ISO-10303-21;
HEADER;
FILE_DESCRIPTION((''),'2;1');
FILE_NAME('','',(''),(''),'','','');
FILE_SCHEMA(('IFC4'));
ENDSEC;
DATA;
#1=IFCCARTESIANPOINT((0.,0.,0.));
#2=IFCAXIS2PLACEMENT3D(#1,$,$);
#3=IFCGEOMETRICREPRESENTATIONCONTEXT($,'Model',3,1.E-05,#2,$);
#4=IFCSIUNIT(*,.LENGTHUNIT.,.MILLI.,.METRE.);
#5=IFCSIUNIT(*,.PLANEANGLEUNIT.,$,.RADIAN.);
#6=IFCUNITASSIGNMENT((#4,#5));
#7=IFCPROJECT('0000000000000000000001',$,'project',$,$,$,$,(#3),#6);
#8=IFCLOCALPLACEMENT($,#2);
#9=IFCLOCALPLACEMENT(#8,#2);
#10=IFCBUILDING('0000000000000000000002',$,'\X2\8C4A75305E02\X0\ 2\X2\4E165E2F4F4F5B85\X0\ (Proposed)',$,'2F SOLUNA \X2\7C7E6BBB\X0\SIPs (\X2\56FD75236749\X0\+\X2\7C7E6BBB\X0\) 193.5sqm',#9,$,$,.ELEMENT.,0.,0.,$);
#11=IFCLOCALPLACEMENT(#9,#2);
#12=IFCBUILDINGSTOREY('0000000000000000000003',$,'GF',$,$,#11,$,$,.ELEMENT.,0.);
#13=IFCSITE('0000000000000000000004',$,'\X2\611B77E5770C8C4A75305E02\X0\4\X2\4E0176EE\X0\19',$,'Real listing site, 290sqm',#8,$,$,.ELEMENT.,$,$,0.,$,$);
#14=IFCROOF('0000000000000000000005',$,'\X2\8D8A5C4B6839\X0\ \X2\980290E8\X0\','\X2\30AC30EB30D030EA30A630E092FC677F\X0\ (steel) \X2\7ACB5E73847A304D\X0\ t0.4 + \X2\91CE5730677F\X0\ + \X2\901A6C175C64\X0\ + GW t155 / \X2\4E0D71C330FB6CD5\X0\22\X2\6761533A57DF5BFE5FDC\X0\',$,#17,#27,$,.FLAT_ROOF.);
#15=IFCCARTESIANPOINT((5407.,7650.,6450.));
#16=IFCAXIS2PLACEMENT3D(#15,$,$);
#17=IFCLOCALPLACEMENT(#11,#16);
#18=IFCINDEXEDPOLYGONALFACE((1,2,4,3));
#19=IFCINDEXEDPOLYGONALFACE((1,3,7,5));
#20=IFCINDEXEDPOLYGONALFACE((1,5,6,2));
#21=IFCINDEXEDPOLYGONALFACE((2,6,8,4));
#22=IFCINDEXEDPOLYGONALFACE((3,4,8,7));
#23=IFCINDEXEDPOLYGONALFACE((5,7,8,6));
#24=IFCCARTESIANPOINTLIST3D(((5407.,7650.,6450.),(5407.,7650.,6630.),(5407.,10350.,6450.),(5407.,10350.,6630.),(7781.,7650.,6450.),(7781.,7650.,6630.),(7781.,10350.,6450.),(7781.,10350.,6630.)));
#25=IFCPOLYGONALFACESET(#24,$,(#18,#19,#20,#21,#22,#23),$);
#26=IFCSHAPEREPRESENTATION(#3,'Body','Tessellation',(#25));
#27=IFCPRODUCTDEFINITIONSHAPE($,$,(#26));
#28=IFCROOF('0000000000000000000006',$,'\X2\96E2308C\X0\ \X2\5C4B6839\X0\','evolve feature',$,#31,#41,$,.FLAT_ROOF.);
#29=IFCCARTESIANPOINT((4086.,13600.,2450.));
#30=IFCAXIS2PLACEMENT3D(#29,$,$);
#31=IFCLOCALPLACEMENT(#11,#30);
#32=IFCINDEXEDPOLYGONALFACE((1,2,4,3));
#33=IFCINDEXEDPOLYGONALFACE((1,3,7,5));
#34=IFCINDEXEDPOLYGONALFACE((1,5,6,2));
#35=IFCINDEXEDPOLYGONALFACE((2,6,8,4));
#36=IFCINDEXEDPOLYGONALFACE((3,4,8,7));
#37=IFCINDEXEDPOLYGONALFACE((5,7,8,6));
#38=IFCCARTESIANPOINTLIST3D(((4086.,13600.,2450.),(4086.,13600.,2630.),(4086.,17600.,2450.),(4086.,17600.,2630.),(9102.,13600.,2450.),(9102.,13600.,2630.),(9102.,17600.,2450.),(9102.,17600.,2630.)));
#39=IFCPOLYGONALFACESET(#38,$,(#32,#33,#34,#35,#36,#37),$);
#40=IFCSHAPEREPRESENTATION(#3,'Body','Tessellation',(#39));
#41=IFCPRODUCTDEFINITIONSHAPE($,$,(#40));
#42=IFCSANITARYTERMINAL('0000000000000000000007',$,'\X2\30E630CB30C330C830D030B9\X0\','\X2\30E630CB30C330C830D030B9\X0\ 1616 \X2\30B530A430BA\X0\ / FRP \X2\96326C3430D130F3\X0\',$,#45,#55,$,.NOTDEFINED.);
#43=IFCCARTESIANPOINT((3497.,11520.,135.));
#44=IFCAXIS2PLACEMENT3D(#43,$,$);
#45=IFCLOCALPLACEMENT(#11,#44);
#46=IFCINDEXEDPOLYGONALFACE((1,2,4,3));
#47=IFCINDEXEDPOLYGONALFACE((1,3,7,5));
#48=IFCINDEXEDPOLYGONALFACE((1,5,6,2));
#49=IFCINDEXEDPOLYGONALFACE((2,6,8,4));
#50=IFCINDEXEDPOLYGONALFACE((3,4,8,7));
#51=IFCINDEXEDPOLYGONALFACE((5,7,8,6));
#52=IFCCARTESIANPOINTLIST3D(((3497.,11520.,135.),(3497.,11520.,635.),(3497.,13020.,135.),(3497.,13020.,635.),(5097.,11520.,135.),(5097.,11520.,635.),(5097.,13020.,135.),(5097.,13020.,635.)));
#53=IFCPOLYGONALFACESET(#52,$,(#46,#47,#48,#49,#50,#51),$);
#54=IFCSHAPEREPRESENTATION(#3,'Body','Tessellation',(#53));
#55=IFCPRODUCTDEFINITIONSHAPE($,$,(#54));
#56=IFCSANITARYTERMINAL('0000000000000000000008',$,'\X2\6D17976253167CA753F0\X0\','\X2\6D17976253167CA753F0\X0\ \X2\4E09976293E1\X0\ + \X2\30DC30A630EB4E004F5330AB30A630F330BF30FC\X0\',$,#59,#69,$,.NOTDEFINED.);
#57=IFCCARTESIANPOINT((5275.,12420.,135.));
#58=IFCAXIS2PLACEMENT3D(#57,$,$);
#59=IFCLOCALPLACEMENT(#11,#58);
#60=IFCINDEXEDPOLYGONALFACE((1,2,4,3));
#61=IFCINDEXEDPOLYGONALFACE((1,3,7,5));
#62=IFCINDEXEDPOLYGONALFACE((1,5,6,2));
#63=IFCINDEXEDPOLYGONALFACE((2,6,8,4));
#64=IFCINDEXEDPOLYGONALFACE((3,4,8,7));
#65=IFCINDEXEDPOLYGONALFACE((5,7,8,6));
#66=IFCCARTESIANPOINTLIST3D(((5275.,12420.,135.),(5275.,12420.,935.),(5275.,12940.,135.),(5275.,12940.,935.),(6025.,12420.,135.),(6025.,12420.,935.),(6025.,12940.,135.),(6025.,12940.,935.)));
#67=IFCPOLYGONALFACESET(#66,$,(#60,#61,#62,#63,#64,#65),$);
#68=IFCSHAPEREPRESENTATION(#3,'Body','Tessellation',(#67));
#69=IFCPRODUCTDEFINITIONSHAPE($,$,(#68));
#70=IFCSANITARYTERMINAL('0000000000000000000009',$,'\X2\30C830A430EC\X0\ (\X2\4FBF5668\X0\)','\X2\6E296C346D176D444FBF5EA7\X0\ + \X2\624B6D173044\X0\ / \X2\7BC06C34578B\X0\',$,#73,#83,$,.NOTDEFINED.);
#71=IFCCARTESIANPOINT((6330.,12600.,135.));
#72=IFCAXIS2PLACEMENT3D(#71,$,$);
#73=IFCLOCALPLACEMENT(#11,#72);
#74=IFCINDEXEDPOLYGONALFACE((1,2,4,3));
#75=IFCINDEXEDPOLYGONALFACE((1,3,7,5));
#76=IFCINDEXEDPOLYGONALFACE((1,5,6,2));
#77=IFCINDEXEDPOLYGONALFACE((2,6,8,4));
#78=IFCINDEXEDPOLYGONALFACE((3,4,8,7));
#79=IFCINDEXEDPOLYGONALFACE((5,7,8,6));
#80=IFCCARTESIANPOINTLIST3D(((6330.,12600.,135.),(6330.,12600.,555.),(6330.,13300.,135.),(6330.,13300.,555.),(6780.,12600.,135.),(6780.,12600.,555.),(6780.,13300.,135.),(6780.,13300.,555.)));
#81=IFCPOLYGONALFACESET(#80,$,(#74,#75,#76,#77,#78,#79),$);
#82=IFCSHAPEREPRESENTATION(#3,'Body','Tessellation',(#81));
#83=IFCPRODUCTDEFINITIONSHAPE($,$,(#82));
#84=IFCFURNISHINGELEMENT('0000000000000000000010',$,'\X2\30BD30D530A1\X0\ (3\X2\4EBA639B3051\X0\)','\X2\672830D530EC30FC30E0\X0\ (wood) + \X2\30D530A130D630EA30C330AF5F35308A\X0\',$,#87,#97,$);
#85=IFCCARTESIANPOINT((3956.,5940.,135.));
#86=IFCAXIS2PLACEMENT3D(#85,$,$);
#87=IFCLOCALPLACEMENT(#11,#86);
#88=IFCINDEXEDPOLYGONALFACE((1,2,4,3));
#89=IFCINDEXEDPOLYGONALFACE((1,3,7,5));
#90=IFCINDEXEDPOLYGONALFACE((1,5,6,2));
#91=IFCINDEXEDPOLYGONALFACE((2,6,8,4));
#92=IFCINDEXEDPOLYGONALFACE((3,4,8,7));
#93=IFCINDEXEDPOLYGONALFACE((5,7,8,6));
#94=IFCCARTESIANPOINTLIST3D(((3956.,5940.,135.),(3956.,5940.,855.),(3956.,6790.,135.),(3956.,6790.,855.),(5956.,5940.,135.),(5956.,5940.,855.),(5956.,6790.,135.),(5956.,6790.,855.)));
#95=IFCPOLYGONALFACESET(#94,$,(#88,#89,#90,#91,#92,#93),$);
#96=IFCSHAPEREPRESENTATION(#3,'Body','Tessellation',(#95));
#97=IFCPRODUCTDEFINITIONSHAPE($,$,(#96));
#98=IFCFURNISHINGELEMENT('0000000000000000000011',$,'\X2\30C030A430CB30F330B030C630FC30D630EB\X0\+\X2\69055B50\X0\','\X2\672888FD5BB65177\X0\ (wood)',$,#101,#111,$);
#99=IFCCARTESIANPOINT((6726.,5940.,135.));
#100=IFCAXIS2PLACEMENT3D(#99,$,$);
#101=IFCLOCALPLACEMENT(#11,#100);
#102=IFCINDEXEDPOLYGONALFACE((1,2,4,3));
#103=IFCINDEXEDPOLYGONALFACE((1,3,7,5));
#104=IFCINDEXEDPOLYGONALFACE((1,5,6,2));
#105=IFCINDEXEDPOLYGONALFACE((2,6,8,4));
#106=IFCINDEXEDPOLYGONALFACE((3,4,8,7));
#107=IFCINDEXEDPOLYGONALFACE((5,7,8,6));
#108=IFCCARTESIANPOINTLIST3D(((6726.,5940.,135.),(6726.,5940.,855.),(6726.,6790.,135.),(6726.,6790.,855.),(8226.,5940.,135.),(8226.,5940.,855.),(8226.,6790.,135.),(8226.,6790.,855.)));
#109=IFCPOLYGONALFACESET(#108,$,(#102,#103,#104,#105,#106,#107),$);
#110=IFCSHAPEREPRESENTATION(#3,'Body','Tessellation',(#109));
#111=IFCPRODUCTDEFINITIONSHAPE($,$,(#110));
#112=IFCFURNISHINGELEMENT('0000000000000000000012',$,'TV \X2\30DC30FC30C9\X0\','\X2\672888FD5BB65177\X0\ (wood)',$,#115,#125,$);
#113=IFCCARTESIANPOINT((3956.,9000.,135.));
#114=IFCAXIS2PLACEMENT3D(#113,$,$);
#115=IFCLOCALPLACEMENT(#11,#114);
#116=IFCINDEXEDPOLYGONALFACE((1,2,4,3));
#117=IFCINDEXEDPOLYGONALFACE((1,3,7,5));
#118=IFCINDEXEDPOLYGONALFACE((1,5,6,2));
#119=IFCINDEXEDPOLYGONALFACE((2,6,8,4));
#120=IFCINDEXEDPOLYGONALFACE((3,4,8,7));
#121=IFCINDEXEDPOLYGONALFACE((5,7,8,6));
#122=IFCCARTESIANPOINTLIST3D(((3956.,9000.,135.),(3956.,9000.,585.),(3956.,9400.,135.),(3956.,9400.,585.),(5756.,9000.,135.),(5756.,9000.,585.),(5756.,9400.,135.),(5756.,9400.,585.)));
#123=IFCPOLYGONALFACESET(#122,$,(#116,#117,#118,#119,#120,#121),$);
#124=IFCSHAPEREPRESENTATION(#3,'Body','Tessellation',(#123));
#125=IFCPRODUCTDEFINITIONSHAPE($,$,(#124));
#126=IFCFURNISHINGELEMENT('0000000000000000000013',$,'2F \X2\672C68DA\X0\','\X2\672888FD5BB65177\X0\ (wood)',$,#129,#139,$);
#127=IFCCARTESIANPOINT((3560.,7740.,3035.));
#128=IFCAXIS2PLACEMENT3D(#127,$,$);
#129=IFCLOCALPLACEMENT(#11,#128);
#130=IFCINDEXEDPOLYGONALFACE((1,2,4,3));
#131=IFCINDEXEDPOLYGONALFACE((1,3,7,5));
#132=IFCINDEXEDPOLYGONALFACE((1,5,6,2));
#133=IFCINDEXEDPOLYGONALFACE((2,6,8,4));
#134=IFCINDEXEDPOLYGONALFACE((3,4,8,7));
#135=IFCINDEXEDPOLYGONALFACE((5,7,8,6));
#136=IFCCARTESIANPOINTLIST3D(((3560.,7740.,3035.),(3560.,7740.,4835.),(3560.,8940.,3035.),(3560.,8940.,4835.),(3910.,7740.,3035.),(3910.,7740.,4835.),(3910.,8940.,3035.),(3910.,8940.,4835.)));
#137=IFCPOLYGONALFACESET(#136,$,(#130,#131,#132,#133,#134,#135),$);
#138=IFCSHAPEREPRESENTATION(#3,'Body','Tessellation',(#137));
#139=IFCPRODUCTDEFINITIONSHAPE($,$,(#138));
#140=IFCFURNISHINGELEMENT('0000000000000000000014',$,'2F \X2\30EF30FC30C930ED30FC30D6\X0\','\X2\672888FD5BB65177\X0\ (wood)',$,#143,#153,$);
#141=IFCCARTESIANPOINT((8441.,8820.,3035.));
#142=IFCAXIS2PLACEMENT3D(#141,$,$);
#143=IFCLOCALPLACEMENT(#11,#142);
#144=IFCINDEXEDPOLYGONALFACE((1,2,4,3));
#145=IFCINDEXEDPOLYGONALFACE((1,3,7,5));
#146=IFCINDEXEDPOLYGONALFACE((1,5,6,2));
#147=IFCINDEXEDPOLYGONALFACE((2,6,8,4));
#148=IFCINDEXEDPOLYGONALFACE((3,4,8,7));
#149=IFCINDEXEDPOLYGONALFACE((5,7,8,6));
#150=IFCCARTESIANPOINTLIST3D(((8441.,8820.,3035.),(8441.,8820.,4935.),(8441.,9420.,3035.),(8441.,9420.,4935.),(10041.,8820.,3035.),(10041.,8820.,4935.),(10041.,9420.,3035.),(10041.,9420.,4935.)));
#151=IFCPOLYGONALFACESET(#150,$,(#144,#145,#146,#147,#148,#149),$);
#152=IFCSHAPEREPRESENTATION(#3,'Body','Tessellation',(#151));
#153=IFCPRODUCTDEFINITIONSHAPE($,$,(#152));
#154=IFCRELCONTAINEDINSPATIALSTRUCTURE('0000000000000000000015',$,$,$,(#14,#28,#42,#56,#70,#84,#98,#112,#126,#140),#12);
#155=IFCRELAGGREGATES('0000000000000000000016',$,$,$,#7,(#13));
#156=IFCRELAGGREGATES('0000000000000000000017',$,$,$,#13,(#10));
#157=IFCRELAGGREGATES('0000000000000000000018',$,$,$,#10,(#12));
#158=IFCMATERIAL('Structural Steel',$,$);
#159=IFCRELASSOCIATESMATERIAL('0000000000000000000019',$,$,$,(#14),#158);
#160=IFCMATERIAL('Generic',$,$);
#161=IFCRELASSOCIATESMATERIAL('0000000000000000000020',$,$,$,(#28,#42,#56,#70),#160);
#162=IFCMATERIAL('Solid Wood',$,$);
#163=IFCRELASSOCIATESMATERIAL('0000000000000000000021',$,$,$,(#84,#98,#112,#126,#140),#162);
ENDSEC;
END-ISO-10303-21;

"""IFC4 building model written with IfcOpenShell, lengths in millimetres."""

from ifc_helpers import new_model, si_unit, frame, frame_2d, origin, place, context, project, spatial, rectangle, extrude, material, element, save


model = new_model("IFC4")

# Units and contexts
model_context = context("Model", 3, precision=1e-05, world=origin())
ifc_project = project(units=[si_unit("LENGTHUNIT", "METRE", prefix="MILLI"), si_unit("PLANEANGLEUNIT", "RADIAN")], contexts=[model_context])

# Site, building, storey
site_placement = place(None, origin())
site = spatial("IfcSite", under=ifc_project, at=site_placement, Name="愛知県豊田市4丁目19", ObjectType="Real listing site, 290sqm", CompositionType="ELEMENT", RefElevation=0.0)
building_placement = place(site_placement, origin())
building = spatial("IfcBuilding", under=site, at=building_placement, Name="豊田市 2世帯住宅 (Proposed)", ObjectType="2F SOLUNA 籾殻SIPs (国産杉+籾殻) 193.5sqm", CompositionType="ELEMENT", ElevationOfRefHeight=0.0, ElevationOfTerrain=0.0)
storey_placement = place(building_placement, origin())
storey = spatial("IfcBuildingStorey", under=building, at=storey_placement, Name="GF", CompositionType="ELEMENT", Elevation=0.0)

# Shared definitions
ifc_material_1 = material(Name="Generic")

# Shared definitions
ifc_material_2 = material(Name="Solid Wood")

# Roofs
ifc_material_3 = material(Name="Structural Steel")
roof_1_placement = place(storey_placement, frame((5407.0, 7650.0, 6450.0)))
element("IfcRoof", 1, at=roof_1_placement, inside=storey, material=ifc_material_3, Name="越屋根 頂部", Description="ガルバリウム鋼板 (steel) 立平葺き t0.4 + 野地板 + 通気層 + GW t155 / 不燃・法22条区域対応", PredefinedType="FLAT_ROOF", context=model_context, shape_type="SweptSolid", body=[
    extrude(rectangle(XDim=2374.0, YDim=2700.0, at=frame_2d((1187.0, 1350.0))), frame((5407.0, 7650.0, 6450.0)), (0.0, 0.0, 1.0), 180.0),
])
roof_2_placement = place(storey_placement, frame((4086.0, 13600.0, 2450.0)))
element("IfcRoof", 2, at=roof_2_placement, inside=storey, material=ifc_material_1, Name="離れ 屋根", Description="evolve feature", PredefinedType="FLAT_ROOF", context=model_context, shape_type="SweptSolid", body=[
    extrude(rectangle(XDim=5016.0, YDim=4000.0, at=frame_2d((2508.0, 2000.0))), frame((4086.0, 13600.0, 2450.0)), (0.0, 0.0, 1.0), 180.0),
])

# Sanitary terminals
sanitary_terminal_1_placement = place(storey_placement, frame((3497.0, 11520.0, 135.0)))
element("IfcSanitaryTerminal", 3, at=sanitary_terminal_1_placement, inside=storey, material=ifc_material_1, Name="ユニットバス", Description="ユニットバス 1616 サイズ / FRP 防水パン", PredefinedType="NOTDEFINED", context=model_context, shape_type="SweptSolid", body=[
    extrude(rectangle(XDim=1600.0, YDim=1500.0, at=frame_2d((800.0, 750.0))), frame((3497.0, 11520.0, 135.0)), (0.0, 0.0, 1.0), 500.0),
])
sanitary_terminal_2_placement = place(storey_placement, frame((5275.0, 12420.0, 135.0)))
element("IfcSanitaryTerminal", 4, at=sanitary_terminal_2_placement, inside=storey, material=ifc_material_1, Name="洗面化粧台", Description="洗面化粧台 三面鏡 + ボウル一体カウンター", PredefinedType="NOTDEFINED", context=model_context, shape_type="SweptSolid", body=[
    extrude(rectangle(XDim=750.0, YDim=520.0, at=frame_2d((375.0, 260.0))), frame((5275.0, 12420.0, 135.0)), (0.0, 0.0, 1.0), 800.0),
])
sanitary_terminal_3_placement = place(storey_placement, frame((6330.0, 12600.0, 135.0)))
element("IfcSanitaryTerminal", 5, at=sanitary_terminal_3_placement, inside=storey, material=ifc_material_1, Name="トイレ (便器)", Description="温水洗浄便座 + 手洗い / 節水型", PredefinedType="NOTDEFINED", context=model_context, shape_type="SweptSolid", body=[
    extrude(rectangle(XDim=450.0, YDim=700.0, at=frame_2d((225.0, 350.0))), frame((6330.0, 12600.0, 135.0)), (0.0, 0.0, 1.0), 420.0),
])

# Furnishing elements
furnishing_1_placement = place(storey_placement, frame((3956.0, 5940.0, 135.0)))
element("IfcFurnishingElement", 6, at=furnishing_1_placement, inside=storey, material=ifc_material_2, Name="ソファ (3人掛け)", Description="木フレーム (wood) + ファブリック張り", context=model_context, shape_type="SweptSolid", body=[
    extrude(rectangle(XDim=2000.0, YDim=850.0, at=frame_2d((1000.0, 425.0))), frame((3956.0, 5940.0, 135.0)), (0.0, 0.0, 1.0), 720.0),
])
furnishing_2_placement = place(storey_placement, frame((6726.0, 5940.0, 135.0)))
element("IfcFurnishingElement", 7, at=furnishing_2_placement, inside=storey, material=ifc_material_2, Name="ダイニングテーブル+椅子", Description="木製家具 (wood)", context=model_context, shape_type="SweptSolid", body=[
    extrude(rectangle(XDim=1500.0, YDim=850.0, at=frame_2d((750.0, 425.0))), frame((6726.0, 5940.0, 135.0)), (0.0, 0.0, 1.0), 720.0),
])
furnishing_3_placement = place(storey_placement, frame((3956.0, 9000.0, 135.0)))
element("IfcFurnishingElement", 8, at=furnishing_3_placement, inside=storey, material=ifc_material_2, Name="TV ボード", Description="木製家具 (wood)", context=model_context, shape_type="SweptSolid", body=[
    extrude(rectangle(XDim=1800.0, YDim=400.0, at=frame_2d((900.0, 200.0))), frame((3956.0, 9000.0, 135.0)), (0.0, 0.0, 1.0), 450.0),
])
furnishing_4_placement = place(storey_placement, frame((3560.0, 7740.0, 3035.0)))
element("IfcFurnishingElement", 9, at=furnishing_4_placement, inside=storey, material=ifc_material_2, Name="2F 本棚", Description="木製家具 (wood)", context=model_context, shape_type="SweptSolid", body=[
    extrude(rectangle(XDim=350.0, YDim=1200.0, at=frame_2d((175.0, 600.0))), frame((3560.0, 7740.0, 3035.0)), (0.0, 0.0, 1.0), 1800.0),
])
furnishing_5_placement = place(storey_placement, frame((8441.0, 8820.0, 3035.0)))
element("IfcFurnishingElement", 10, at=furnishing_5_placement, inside=storey, material=ifc_material_2, Name="2F ワードローブ", Description="木製家具 (wood)", context=model_context, shape_type="SweptSolid", body=[
    extrude(rectangle(XDim=1600.0, YDim=600.0, at=frame_2d((800.0, 300.0))), frame((8441.0, 8820.0, 3035.0)), (0.0, 0.0, 1.0), 1900.0),
])

save(model, "model.ifc")
